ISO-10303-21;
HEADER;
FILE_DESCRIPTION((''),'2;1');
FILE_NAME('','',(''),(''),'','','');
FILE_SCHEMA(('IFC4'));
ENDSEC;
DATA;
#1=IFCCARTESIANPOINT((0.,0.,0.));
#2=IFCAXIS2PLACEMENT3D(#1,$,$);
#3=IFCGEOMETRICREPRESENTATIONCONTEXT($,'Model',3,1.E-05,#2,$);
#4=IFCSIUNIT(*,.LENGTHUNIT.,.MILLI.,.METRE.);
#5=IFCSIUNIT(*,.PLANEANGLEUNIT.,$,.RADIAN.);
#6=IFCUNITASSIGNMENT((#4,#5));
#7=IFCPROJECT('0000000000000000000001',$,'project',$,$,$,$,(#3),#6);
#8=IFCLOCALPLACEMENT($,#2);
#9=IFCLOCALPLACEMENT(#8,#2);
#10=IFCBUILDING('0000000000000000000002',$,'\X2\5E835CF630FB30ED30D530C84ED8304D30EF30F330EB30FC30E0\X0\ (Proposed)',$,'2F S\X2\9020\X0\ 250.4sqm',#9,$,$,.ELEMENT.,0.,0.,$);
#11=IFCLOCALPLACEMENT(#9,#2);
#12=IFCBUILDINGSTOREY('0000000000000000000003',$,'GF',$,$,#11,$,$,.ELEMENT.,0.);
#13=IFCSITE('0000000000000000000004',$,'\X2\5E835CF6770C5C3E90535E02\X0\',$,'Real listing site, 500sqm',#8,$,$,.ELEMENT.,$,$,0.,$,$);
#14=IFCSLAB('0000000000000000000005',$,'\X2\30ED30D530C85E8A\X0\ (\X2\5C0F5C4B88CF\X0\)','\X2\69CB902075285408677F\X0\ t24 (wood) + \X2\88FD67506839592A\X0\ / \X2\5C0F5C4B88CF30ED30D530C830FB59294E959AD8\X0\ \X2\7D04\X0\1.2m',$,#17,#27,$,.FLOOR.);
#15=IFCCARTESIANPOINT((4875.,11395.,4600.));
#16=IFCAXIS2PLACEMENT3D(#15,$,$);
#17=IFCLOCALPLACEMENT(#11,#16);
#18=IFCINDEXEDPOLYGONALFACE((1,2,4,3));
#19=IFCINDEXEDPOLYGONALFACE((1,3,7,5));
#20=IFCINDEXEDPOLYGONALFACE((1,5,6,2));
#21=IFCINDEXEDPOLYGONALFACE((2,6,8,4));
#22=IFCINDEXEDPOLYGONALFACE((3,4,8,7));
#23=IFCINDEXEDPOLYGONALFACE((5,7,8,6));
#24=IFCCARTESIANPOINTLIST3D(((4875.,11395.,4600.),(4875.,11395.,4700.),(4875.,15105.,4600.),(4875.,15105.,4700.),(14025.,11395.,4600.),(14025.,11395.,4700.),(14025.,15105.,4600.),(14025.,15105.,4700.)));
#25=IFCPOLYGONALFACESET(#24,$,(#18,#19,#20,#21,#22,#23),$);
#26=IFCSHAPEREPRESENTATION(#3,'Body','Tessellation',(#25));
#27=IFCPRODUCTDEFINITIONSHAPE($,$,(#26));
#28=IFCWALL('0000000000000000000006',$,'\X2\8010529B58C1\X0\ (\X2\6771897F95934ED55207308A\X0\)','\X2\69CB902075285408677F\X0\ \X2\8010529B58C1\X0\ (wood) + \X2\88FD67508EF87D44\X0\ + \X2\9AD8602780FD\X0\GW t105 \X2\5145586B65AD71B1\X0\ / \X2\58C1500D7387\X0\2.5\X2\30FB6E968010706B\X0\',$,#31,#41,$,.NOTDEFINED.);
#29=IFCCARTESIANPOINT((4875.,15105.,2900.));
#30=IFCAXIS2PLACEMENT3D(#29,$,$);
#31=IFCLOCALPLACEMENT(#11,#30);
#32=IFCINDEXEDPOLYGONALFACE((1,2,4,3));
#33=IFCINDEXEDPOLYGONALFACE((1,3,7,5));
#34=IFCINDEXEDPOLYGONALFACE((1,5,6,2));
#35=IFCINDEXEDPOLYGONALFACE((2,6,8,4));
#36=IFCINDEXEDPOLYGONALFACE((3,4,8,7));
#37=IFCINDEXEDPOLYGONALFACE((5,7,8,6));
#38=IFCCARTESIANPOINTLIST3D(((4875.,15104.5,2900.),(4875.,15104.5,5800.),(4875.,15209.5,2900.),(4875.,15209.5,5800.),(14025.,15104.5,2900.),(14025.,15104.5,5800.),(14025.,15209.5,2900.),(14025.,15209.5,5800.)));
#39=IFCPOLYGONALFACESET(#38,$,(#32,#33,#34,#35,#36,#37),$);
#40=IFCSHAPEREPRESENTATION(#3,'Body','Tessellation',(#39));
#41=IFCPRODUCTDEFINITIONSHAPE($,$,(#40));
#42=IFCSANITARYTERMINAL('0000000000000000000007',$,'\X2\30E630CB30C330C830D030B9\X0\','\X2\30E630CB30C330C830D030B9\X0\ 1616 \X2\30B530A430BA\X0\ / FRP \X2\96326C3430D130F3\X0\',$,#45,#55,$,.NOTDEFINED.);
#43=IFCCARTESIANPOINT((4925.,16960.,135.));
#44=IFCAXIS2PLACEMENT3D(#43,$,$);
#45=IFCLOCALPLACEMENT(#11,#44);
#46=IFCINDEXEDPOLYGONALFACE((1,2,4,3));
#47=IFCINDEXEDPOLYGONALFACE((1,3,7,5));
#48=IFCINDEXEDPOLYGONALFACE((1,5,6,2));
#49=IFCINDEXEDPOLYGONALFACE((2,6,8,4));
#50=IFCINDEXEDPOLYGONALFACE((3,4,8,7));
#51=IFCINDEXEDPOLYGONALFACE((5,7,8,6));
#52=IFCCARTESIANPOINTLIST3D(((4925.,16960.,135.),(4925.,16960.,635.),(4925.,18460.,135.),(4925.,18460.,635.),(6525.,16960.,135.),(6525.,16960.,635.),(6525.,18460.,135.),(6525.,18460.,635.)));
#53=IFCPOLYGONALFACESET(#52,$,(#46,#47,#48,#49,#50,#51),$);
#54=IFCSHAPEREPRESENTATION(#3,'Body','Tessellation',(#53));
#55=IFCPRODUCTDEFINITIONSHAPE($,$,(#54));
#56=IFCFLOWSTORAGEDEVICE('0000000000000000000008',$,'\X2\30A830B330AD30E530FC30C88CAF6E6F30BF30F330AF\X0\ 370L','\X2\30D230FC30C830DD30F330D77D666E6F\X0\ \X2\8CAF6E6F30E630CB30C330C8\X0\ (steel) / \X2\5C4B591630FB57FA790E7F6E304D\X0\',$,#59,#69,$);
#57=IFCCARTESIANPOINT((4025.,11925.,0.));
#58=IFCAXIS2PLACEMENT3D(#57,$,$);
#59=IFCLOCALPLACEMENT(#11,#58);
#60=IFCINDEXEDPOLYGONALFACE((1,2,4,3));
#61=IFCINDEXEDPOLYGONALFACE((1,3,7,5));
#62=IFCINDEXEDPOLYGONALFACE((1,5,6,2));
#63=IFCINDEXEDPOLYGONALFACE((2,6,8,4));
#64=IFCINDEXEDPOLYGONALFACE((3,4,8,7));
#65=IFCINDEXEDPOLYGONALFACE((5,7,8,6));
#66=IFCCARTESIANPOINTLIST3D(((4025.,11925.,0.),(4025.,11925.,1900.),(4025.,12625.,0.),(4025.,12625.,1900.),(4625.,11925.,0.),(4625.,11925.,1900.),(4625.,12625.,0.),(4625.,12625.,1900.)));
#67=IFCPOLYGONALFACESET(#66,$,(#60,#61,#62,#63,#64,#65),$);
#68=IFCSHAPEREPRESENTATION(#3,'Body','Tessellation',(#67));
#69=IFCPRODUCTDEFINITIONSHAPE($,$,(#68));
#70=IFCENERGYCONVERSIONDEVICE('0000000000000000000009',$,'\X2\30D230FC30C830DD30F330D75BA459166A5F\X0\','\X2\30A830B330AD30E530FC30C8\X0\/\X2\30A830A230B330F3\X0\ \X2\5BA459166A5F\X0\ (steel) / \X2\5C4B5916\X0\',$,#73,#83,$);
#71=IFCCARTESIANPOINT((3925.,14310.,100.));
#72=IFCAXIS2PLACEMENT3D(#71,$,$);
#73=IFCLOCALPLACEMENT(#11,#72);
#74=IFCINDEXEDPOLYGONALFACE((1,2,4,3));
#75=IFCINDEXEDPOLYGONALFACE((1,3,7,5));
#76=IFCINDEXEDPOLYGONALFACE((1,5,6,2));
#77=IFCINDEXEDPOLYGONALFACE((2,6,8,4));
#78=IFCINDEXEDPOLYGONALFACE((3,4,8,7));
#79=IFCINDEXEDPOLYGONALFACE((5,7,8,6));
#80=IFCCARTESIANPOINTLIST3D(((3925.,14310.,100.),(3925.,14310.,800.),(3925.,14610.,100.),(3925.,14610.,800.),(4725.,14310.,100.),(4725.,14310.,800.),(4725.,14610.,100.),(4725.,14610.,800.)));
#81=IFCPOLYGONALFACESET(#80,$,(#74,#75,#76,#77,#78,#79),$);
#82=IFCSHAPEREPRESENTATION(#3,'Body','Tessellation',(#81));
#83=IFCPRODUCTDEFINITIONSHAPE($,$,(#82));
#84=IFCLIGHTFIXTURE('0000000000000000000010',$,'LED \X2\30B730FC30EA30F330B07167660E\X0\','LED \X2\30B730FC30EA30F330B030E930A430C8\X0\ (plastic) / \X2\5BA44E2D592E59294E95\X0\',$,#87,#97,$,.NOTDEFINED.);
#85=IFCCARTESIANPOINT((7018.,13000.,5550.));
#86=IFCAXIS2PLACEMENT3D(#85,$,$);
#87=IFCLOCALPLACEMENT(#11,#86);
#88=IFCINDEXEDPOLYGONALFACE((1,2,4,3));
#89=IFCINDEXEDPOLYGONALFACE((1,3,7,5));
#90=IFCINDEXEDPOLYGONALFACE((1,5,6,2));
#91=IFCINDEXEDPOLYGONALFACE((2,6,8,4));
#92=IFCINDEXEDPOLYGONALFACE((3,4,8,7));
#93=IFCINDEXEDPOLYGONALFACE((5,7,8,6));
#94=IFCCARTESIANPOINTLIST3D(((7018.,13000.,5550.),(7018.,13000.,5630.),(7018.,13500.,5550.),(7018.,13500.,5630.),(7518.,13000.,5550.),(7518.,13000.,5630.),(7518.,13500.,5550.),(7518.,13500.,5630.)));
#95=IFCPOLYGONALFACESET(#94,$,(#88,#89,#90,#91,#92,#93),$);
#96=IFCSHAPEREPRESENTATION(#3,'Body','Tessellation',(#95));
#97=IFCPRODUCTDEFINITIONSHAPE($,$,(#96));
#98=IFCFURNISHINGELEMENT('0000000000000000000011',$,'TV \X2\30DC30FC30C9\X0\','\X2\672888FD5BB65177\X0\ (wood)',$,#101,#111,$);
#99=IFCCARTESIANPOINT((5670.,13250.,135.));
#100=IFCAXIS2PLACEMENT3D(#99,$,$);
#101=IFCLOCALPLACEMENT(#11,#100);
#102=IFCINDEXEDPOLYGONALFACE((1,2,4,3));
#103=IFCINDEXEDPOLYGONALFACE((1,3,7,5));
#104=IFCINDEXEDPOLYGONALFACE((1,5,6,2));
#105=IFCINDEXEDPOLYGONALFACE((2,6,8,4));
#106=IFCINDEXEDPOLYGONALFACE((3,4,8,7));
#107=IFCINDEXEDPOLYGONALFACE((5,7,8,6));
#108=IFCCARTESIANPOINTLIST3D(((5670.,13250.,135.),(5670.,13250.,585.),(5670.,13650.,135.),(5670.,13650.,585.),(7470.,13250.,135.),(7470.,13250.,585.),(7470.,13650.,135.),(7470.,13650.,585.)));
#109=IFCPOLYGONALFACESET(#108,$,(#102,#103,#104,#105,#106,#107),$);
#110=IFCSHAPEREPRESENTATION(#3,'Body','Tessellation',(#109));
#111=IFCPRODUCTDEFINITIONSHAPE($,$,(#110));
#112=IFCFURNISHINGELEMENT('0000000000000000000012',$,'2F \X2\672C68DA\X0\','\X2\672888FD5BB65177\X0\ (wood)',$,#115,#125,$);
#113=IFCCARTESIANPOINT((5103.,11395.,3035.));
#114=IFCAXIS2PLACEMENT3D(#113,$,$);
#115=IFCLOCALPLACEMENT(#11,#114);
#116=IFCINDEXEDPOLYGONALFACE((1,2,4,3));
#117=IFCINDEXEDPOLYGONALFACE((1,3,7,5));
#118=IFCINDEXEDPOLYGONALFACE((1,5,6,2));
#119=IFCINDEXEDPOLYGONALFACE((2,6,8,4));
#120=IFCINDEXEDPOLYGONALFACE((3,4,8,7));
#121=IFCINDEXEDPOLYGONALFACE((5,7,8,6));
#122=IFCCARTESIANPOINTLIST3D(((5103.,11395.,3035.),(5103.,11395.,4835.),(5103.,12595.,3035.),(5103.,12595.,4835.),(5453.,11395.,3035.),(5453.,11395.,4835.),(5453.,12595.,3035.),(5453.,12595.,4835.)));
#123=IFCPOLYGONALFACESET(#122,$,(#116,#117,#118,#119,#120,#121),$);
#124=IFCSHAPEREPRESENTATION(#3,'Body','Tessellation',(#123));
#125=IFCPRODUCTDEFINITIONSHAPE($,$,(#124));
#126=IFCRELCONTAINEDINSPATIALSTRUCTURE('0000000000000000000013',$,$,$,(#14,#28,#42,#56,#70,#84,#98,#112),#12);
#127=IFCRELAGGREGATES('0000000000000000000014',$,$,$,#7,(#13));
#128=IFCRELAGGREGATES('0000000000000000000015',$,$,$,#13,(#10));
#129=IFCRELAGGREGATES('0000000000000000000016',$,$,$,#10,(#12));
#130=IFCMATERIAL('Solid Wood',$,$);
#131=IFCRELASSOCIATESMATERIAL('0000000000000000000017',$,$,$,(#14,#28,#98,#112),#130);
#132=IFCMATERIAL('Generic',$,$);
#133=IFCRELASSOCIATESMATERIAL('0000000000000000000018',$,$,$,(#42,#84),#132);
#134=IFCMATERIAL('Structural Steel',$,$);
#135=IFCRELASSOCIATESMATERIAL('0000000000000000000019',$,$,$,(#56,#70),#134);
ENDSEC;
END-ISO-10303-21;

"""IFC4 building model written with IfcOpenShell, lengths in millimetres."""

from ifc_helpers import new_model, si_unit, frame, frame_2d, origin, place, context, project, spatial, rectangle, extrude, material, element, save


model = new_model("IFC4")

# Units and contexts
model_context = context("Model", 3, precision=1e-05, world=origin())
ifc_project = project(units=[si_unit("LENGTHUNIT", "METRE", prefix="MILLI"), si_unit("PLANEANGLEUNIT", "RADIAN")], contexts=[model_context])

# Site, building, storey
site_placement = place(None, origin())
site = spatial("IfcSite", under=ifc_project, at=site_placement, Name="広島県尾道市", ObjectType="Real listing site, 500sqm", CompositionType="ELEMENT", RefElevation=0.0)
building_placement = place(site_placement, origin())
building = spatial("IfcBuilding", under=site, at=building_placement, Name="広島・ロフト付きワンルーム (Proposed)", ObjectType="2F S造 250.4sqm", CompositionType="ELEMENT", ElevationOfRefHeight=0.0, ElevationOfTerrain=0.0)
storey_placement = place(building_placement, origin())
storey = spatial("IfcBuildingStorey", under=building, at=storey_placement, Name="GF", CompositionType="ELEMENT", Elevation=0.0)

# Shared definitions
ifc_material_1 = material(Name="Solid Wood")

# Slab
slab_placement = place(storey_placement, frame((4875.0, 11395.0, 4600.0)))
element("IfcSlab", 1, at=slab_placement, inside=storey, material=ifc_material_1, Name="ロフト床 (小屋裏)", Description="構造用合板 t24 (wood) + 製材根太 / 小屋裏ロフト・天井高 約1.2m", PredefinedType="FLOOR", context=model_context, shape_type="SweptSolid", body=[
    extrude(rectangle(XDim=9150.0, YDim=3710.0, at=frame_2d((4575.0, 1855.0))), frame((4875.0, 11395.0, 4600.0)), (0.0, 0.0, 1.0), 100.0),
])

# Wall
wall_1_placement = place(storey_placement, frame((4875.0, 15105.0, 2900.0)))
element("IfcWall", 2, at=wall_1_placement, inside=storey, material=ifc_material_1, Name="耐力壁 (東西間仕切り)", Description="構造用合板 耐力壁 (wood) + 製材軸組 + 高性能GW t105 充填断熱 / 壁倍率2.5・準耐火", PredefinedType="NOTDEFINED", context=model_context, shape_type="SweptSolid", body=[
    extrude(rectangle(XDim=9150.0, YDim=105.0, at=frame_2d((4575.0, 52.0))), frame((4875.0, 15105.0, 2900.0)), (0.0, 0.0, 1.0), 2900.0),
])

# Sanitary terminal
ifc_material_2 = material(Name="Generic")
sanitary_terminal_placement = place(storey_placement, frame((4925.0, 16960.0, 135.0)))
element("IfcSanitaryTerminal", 3, at=sanitary_terminal_placement, inside=storey, material=ifc_material_2, Name="ユニットバス", Description="ユニットバス 1616 サイズ / FRP 防水パン", PredefinedType="NOTDEFINED", context=model_context, shape_type="SweptSolid", body=[
    extrude(rectangle(XDim=1600.0, YDim=1500.0, at=frame_2d((800.0, 750.0))), frame((4925.0, 16960.0, 135.0)), (0.0, 0.0, 1.0), 500.0),
])

# Flow storage device
ifc_material_3 = material(Name="Structural Steel")
flow_storage_device_placement = place(storey_placement, frame((4025.0, 11925.0, 0.0)))
element("IfcFlowStorageDevice", 4, at=flow_storage_device_placement, inside=storey, material=ifc_material_3, Name="エコキュート貯湯タンク 370L", Description="ヒートポンプ給湯 貯湯ユニット (steel) / 屋外・基礎置き", context=model_context, shape_type="SweptSolid", body=[
    extrude(rectangle(XDim=600.0, YDim=700.0, at=frame_2d((300.0, 350.0))), frame((4025.0, 11925.0, 0.0)), (0.0, 0.0, 1.0), 1900.0),
])

# Energy conversion device
energy_conversion_device_placement = place(storey_placement, frame((3925.0, 14310.0, 100.0)))
element("IfcEnergyConversionDevice", 5, at=energy_conversion_device_placement, inside=storey, material=ifc_material_3, Name="ヒートポンプ室外機", Description="エコキュート/エアコン 室外機 (steel) / 屋外", context=model_context, shape_type="SweptSolid", body=[
    extrude(rectangle(XDim=800.0, YDim=300.0, at=frame_2d((400.0, 150.0))), frame((3925.0, 14310.0, 100.0)), (0.0, 0.0, 1.0), 700.0),
])

# Light fixture
light_fixture_placement = place(storey_placement, frame((7018.0, 13000.0, 5550.0)))
element("IfcLightFixture", 6, at=light_fixture_placement, inside=storey, material=ifc_material_2, Name="LED シーリング照明", Description="LED シーリングライト (plastic) / 室中央天井", PredefinedType="NOTDEFINED", context=model_context, shape_type="SweptSolid", body=[
    extrude(rectangle(XDim=500.0, YDim=500.0, at=frame_2d((250.0, 250.0))), frame((7018.0, 13000.0, 5550.0)), (0.0, 0.0, 1.0), 80.0),
])

# Furnishing elements
furnishing_1_placement = place(storey_placement, frame((5670.0, 13250.0, 135.0)))
element("IfcFurnishingElement", 7, at=furnishing_1_placement, inside=storey, material=ifc_material_1, Name="TV ボード", Description="木製家具 (wood)", context=model_context, shape_type="SweptSolid", body=[
    extrude(rectangle(XDim=1800.0, YDim=400.0, at=frame_2d((900.0, 200.0))), frame((5670.0, 13250.0, 135.0)), (0.0, 0.0, 1.0), 450.0),
])
furnishing_2_placement = place(storey_placement, frame((5103.0, 11395.0, 3035.0)))
element("IfcFurnishingElement", 8, at=furnishing_2_placement, inside=storey, material=ifc_material_1, Name="2F 本棚", Description="木製家具 (wood)", context=model_context, shape_type="SweptSolid", body=[
    extrude(rectangle(XDim=350.0, YDim=1200.0, at=frame_2d((175.0, 600.0))), frame((5103.0, 11395.0, 3035.0)), (0.0, 0.0, 1.0), 1800.0),
])

save(model, "model.ifc")
